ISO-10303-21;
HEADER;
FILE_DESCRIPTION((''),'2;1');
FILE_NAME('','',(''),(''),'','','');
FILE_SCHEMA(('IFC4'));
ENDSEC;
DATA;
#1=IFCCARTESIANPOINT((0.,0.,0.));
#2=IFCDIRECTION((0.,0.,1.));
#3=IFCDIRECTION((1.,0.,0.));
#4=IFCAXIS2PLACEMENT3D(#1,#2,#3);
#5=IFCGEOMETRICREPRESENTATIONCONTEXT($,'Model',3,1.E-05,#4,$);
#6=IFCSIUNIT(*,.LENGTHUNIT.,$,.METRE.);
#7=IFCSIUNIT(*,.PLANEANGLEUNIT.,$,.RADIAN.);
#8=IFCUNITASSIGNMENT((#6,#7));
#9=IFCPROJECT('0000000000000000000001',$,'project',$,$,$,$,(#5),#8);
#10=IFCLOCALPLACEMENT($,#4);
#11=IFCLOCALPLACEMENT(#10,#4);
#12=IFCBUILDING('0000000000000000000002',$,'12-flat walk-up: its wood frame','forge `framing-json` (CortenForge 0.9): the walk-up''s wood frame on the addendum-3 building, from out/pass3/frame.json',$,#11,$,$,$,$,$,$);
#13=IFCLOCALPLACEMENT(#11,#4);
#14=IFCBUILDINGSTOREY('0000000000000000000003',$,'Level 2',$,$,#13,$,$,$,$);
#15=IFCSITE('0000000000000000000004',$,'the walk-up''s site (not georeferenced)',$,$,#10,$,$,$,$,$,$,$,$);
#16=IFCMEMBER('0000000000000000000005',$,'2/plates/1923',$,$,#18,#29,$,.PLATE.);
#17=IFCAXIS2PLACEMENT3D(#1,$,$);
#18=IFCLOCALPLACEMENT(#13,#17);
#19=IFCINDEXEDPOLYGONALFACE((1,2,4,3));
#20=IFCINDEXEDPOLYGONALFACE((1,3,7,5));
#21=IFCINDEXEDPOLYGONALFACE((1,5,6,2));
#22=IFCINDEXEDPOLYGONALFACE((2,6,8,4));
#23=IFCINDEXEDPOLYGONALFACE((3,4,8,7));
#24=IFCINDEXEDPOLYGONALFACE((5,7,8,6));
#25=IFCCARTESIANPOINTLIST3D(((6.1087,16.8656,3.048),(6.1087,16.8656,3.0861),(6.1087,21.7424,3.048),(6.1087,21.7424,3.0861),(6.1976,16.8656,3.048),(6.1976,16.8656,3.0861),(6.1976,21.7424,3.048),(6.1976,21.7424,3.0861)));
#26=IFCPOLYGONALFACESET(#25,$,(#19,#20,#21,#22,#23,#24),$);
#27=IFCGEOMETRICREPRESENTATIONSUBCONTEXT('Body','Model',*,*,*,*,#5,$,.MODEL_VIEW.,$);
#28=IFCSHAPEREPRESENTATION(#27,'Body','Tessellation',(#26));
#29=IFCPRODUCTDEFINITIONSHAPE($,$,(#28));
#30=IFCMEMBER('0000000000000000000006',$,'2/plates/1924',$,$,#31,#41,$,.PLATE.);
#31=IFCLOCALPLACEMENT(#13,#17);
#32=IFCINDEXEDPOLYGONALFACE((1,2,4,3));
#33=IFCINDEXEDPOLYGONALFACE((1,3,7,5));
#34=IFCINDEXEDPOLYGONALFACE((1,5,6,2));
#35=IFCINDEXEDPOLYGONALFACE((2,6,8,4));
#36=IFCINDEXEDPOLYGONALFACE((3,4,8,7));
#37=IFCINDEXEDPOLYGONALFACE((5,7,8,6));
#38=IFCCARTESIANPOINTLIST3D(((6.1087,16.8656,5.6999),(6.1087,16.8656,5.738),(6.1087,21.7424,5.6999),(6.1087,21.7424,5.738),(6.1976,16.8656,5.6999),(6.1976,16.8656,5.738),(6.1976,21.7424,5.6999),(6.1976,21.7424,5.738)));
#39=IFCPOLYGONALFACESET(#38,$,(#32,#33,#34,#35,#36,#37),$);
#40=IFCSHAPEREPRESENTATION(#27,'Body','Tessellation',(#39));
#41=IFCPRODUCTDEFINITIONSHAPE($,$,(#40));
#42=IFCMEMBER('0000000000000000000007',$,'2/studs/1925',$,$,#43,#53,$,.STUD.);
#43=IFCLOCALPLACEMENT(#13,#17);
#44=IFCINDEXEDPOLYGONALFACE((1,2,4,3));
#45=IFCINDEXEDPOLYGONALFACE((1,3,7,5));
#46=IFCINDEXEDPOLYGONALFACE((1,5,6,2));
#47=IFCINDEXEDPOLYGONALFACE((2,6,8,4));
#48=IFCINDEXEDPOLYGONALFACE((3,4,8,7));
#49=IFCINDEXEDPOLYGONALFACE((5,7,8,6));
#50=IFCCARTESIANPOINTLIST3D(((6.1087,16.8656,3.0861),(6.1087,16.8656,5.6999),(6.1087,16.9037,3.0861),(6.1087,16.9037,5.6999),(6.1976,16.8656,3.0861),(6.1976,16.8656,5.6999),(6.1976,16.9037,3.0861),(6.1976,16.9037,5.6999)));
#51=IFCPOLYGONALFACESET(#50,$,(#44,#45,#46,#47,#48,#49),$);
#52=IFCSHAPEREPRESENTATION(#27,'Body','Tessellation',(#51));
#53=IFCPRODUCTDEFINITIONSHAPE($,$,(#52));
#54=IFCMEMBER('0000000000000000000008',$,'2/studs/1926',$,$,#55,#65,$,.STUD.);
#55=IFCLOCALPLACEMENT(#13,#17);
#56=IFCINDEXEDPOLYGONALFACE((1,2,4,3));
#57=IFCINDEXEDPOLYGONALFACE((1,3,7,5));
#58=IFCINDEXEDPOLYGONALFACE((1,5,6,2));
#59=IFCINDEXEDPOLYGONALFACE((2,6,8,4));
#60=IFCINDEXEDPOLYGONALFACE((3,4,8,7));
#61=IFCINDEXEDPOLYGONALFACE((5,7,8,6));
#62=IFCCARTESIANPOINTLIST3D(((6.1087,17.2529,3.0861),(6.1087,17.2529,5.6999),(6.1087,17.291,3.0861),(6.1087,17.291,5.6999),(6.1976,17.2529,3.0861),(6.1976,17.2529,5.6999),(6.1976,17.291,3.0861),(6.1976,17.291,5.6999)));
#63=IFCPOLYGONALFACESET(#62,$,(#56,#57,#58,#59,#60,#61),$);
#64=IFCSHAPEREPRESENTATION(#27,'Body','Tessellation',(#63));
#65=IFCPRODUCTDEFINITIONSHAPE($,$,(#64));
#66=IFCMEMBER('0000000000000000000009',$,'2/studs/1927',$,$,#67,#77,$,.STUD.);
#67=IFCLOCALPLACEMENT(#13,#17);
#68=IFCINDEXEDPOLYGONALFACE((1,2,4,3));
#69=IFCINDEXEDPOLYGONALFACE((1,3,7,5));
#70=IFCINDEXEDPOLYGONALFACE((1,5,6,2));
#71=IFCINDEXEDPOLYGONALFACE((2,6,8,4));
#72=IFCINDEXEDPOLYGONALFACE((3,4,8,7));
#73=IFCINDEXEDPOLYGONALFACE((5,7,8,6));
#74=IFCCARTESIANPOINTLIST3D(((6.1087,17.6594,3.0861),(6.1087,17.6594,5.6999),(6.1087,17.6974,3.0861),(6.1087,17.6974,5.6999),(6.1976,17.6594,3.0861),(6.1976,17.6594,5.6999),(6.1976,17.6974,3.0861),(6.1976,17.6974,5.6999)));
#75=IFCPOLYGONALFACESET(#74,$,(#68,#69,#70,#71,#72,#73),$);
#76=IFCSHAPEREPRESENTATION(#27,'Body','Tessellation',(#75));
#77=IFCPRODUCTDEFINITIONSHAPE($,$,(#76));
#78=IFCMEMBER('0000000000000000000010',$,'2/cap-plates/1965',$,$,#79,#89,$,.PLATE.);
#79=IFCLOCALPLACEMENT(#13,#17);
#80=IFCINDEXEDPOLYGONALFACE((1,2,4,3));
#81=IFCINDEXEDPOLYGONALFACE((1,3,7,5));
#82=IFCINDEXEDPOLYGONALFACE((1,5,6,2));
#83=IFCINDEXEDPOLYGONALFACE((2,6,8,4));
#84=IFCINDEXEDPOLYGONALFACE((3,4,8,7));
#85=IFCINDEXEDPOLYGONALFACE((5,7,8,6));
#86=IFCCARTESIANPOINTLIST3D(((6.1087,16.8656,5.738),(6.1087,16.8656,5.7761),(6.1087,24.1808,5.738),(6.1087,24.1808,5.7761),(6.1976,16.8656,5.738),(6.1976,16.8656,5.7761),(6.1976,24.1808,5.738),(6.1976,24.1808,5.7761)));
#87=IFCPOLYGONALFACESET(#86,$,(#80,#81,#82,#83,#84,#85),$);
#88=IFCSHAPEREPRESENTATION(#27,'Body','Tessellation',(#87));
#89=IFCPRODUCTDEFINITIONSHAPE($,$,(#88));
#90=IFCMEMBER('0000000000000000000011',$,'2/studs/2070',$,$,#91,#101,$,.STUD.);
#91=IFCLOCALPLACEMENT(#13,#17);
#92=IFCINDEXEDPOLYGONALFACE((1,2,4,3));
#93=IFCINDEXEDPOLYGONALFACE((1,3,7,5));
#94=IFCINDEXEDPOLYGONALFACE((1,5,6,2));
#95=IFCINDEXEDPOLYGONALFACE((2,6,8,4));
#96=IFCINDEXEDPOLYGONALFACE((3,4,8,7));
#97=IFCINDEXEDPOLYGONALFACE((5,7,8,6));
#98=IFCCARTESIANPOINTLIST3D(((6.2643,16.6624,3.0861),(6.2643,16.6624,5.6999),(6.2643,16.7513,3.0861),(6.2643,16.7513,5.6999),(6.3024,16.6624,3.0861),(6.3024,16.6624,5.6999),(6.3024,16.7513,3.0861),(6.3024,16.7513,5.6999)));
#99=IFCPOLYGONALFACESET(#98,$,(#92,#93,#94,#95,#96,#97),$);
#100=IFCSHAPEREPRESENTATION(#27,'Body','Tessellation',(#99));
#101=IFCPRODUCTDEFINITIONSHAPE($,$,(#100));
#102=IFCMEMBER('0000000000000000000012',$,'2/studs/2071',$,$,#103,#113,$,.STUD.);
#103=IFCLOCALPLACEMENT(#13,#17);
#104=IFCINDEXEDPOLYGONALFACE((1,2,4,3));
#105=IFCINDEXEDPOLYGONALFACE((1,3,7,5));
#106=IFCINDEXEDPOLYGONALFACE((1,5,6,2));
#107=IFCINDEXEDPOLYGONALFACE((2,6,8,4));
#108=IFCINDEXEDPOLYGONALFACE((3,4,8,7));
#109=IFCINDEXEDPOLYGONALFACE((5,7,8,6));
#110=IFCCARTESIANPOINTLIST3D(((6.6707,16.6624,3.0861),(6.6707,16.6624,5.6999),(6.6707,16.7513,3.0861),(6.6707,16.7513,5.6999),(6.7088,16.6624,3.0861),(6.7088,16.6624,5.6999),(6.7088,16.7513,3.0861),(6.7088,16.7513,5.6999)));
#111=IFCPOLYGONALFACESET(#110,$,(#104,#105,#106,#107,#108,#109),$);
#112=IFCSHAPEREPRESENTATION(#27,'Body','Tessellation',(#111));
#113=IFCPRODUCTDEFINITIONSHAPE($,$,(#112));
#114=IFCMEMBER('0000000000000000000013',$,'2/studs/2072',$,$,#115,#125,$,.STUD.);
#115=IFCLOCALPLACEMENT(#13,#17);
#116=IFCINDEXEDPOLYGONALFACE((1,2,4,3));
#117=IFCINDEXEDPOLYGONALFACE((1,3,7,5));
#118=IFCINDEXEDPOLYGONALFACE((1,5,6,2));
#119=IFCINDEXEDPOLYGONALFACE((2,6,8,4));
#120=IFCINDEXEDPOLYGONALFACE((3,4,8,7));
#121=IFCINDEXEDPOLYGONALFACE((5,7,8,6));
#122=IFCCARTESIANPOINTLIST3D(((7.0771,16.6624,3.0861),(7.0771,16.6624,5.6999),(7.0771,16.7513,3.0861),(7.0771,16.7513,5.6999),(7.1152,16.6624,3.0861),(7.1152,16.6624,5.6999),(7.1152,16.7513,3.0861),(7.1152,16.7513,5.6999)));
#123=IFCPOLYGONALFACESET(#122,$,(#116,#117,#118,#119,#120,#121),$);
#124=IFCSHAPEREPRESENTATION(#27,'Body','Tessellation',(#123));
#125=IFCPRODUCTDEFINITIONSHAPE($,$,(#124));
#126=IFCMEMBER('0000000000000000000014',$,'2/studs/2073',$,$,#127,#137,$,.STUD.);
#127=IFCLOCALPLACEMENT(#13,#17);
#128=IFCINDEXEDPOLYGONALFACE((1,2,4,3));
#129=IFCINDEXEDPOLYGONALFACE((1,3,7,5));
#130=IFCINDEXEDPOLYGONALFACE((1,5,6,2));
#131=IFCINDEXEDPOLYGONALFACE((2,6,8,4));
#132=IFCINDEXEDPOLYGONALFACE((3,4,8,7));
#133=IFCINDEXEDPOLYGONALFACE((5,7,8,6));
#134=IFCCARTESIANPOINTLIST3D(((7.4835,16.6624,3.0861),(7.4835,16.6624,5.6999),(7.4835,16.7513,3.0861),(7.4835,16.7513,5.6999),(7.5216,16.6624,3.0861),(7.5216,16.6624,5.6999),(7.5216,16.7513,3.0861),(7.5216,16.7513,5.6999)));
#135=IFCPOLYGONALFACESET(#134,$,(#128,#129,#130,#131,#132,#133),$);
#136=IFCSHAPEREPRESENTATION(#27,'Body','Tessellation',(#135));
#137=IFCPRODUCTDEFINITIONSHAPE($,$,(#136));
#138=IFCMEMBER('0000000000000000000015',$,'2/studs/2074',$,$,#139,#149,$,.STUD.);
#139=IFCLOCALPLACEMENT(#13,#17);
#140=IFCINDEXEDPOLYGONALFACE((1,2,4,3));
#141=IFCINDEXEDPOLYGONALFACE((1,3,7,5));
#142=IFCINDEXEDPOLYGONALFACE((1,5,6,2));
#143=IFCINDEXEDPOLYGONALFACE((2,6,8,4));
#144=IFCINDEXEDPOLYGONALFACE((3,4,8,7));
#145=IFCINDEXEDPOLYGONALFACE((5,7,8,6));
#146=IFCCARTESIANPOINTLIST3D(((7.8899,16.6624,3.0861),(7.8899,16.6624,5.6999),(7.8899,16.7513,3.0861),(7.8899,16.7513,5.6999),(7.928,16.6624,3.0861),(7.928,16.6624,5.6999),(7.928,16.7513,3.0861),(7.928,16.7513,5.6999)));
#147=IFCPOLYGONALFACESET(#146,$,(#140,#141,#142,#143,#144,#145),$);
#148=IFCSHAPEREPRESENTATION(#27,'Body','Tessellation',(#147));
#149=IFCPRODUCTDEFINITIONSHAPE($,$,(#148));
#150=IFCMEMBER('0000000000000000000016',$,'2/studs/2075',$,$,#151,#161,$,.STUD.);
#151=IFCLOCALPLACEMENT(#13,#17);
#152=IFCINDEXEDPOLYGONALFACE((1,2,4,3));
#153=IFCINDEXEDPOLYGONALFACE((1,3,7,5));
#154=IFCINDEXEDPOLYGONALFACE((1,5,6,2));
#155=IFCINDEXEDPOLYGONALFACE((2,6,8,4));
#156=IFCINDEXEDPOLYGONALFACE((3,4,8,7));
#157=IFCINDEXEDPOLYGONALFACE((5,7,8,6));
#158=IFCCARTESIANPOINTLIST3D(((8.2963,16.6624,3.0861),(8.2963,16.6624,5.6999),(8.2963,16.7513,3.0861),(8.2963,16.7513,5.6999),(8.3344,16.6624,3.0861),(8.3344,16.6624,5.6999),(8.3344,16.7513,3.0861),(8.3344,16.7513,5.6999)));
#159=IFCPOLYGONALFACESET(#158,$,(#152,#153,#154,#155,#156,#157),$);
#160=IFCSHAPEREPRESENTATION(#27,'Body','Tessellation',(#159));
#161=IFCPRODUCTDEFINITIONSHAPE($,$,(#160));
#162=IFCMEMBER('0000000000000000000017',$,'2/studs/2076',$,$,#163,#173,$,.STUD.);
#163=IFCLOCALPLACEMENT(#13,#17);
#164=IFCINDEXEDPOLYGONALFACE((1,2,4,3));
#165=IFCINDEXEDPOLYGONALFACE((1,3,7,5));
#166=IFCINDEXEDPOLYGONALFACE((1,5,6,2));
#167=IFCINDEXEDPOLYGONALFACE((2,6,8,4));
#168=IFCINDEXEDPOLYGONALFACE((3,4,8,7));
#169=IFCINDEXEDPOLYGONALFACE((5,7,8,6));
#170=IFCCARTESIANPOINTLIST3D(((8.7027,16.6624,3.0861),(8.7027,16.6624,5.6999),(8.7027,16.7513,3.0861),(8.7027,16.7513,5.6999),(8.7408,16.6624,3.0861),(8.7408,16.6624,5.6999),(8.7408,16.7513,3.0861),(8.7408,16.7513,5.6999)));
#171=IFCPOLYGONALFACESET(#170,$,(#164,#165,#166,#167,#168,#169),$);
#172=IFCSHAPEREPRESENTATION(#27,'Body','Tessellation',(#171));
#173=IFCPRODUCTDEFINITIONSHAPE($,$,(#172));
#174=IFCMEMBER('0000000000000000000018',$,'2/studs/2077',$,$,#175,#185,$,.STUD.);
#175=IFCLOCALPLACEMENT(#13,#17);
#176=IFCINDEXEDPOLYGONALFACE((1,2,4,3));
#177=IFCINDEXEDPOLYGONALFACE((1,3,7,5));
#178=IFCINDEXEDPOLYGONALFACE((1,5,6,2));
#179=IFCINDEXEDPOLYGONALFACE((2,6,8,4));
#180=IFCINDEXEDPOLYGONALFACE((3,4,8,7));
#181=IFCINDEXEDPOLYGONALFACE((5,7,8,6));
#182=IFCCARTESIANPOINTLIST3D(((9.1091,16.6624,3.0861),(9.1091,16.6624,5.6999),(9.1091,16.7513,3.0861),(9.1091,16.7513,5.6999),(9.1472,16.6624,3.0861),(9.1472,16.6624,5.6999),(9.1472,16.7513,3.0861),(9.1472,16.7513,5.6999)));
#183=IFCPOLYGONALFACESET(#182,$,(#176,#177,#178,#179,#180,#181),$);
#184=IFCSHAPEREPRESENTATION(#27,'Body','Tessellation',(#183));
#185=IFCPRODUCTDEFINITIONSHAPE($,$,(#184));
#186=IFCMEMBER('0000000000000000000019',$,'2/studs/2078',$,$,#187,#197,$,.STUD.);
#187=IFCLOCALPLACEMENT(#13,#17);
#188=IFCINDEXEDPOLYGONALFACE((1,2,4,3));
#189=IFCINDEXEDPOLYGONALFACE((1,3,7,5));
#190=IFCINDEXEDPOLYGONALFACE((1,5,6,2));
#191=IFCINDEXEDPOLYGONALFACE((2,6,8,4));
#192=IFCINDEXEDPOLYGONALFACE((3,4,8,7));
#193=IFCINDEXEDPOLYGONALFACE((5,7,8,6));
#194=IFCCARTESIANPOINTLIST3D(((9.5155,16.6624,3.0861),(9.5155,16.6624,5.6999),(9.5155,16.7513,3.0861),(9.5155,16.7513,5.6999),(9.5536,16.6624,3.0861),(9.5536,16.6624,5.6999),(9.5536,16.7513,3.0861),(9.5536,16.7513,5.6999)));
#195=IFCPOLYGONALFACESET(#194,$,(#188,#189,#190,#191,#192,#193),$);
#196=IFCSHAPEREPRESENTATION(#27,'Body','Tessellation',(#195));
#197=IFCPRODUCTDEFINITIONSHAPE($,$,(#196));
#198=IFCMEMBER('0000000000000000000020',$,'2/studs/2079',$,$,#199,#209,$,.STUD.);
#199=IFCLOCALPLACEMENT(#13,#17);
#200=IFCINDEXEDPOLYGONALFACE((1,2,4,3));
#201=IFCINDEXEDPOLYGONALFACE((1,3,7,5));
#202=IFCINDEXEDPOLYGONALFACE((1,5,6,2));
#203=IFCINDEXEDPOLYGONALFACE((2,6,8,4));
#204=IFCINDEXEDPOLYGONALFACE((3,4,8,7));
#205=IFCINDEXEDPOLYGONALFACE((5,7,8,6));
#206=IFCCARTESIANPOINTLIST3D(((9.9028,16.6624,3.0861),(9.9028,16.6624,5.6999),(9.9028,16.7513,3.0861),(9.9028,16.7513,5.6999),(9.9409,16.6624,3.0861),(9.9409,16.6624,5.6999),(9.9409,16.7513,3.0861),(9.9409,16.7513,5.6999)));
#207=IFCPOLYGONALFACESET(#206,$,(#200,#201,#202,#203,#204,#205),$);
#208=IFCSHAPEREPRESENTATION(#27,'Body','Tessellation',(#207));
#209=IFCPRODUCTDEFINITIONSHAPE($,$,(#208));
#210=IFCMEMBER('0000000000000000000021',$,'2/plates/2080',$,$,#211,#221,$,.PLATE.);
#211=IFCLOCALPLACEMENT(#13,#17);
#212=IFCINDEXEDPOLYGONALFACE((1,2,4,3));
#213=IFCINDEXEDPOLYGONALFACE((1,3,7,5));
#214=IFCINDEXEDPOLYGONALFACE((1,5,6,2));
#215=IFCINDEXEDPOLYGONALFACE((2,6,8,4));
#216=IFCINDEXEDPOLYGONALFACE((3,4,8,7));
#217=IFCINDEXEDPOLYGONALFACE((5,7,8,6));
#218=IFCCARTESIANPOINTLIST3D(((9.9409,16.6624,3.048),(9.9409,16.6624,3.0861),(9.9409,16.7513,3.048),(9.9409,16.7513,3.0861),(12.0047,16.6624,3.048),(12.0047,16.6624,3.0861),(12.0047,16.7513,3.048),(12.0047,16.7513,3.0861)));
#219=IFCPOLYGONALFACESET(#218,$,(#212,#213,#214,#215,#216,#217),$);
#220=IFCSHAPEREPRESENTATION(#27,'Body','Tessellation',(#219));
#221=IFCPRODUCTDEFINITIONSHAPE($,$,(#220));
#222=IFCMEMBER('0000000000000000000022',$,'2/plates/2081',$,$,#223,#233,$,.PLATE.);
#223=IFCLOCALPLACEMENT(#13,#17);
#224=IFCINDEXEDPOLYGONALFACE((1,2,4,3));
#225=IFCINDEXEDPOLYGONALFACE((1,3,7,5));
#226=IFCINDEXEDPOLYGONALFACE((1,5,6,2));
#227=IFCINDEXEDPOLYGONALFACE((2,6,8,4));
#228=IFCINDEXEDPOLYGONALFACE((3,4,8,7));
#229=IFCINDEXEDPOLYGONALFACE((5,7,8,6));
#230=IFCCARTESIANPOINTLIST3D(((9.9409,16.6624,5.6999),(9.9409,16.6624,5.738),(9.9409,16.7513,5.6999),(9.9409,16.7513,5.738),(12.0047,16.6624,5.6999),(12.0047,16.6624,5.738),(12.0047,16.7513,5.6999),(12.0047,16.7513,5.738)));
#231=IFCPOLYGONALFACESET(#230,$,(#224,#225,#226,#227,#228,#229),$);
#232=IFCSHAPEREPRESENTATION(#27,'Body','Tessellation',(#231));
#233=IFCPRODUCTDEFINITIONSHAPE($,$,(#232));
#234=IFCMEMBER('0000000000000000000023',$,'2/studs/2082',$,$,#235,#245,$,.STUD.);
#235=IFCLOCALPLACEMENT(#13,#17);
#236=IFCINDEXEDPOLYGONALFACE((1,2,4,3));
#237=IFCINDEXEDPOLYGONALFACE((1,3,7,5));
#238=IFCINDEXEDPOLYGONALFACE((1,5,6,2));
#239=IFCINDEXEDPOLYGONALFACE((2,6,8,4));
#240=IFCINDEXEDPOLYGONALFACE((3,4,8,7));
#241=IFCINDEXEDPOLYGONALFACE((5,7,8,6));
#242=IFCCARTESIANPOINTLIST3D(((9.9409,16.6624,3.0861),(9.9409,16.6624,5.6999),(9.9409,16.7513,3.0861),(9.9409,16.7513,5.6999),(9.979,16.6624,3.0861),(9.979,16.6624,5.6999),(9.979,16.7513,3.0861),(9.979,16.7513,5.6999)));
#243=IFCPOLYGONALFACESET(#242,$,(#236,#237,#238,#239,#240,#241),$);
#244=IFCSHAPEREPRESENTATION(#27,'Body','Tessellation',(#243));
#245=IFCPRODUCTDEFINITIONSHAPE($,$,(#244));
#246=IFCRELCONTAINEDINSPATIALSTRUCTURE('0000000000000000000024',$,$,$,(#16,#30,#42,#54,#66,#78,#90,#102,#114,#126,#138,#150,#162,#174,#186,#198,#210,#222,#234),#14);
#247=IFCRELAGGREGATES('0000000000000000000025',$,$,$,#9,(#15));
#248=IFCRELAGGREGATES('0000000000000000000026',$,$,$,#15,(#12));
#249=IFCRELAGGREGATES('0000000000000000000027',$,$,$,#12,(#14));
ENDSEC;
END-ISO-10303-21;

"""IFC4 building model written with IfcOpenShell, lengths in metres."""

from ifc_helpers import new_model, si_unit, frame, frame_2d, origin, origin_with_axes, place, context, subcontext, project, spatial, rectangle, extrude, element, save


model = new_model("IFC4")

# Units and contexts
model_context = context("Model", 3, precision=1e-05, world=origin_with_axes())
body_context = subcontext(model_context, "Body", "Model", "MODEL_VIEW")
ifc_project = project(units=[si_unit("LENGTHUNIT", "METRE"), si_unit("PLANEANGLEUNIT", "RADIAN")], contexts=[model_context])

# Site, building, storey
site_placement = place(None, origin_with_axes())
site = spatial("IfcSite", under=ifc_project, at=site_placement, Name="the walk-up's site (not georeferenced)")
building_placement = place(site_placement, origin_with_axes())
building = spatial("IfcBuilding", under=site, at=building_placement, Name="12-flat walk-up: its wood frame", Description="forge `framing-json` (CortenForge 0.9): the walk-up's wood frame on the addendum-3 building, from out/pass3/frame.json")
storey_placement = place(building_placement, origin_with_axes())
storey = spatial("IfcBuildingStorey", under=building, at=storey_placement, Name="Level 2")

# Members
for number, where, z_axis, x_axis, name in (
    (1, (6.1087, 16.8656, 3.048), (0.0, 0.0, 1.0), (1.0, 0.0, 0.0), "2/plates/1923"),
    (2, (6.1087, 16.8656, 5.6999), (0.0, 0.0, 1.0), (1.0, 0.0, 0.0), "2/plates/1924"),
):
    element("IfcMember", number, at=place(storey_placement, frame(where, z_axis=z_axis, x_axis=x_axis)), inside=storey, Name=name, PredefinedType="PLATE", context=body_context, shape_type="SweptSolid", body=[
        extrude(rectangle(XDim=0.0889, YDim=4.8768, at=frame_2d((0.0445, 2.4384))), origin(), (0.0, 0.0, 1.0), 0.0381),
    ])
for number, where, z_axis, x_axis, name in (
    (3, (6.1087, 16.8656, 3.0861), (0.0, 0.0, 1.0), (1.0, 0.0, 0.0), "2/studs/1925"),
    (4, (6.1087, 17.2529, 3.0861), (0.0, 0.0, 1.0), (1.0, 0.0, 0.0), "2/studs/1926"),
    (5, (6.1087, 17.6593, 3.0861), (0.0, 0.0, 1.0), (1.0, 0.0, 0.0), "2/studs/1927"),
):
    element("IfcMember", number, at=place(storey_placement, frame(where, z_axis=z_axis, x_axis=x_axis)), inside=storey, Name=name, PredefinedType="STUD", context=body_context, shape_type="SweptSolid", body=[
        extrude(rectangle(XDim=0.0889, YDim=0.0381, at=frame_2d((0.0445, 0.0191))), origin(), (0.0, 0.0, 1.0), 2.6138),
    ])
member_1_placement = place(storey_placement, frame((6.1087, 16.8656, 5.738), z_axis=(0.0, 0.0, 1.0), x_axis=(1.0, 0.0, 0.0)))
element("IfcMember", 6, at=member_1_placement, inside=storey, Name="2/cap-plates/1965", PredefinedType="PLATE", context=body_context, shape_type="SweptSolid", body=[
    extrude(rectangle(XDim=0.0889, YDim=7.3152, at=frame_2d((0.0445, 3.6576))), origin(), (0.0, 0.0, 1.0), 0.0381),
])
for number, where, z_axis, x_axis, name in (
    (7, (6.2643, 16.6624, 3.0861), (0.0, 0.0, 1.0), (1.0, 0.0, 0.0), "2/studs/2070"),
    (8, (6.6707, 16.6624, 3.0861), (0.0, 0.0, 1.0), (1.0, 0.0, 0.0), "2/studs/2071"),
    (9, (7.0771, 16.6624, 3.0861), (0.0, 0.0, 1.0), (1.0, 0.0, 0.0), "2/studs/2072"),
    (10, (7.4835, 16.6624, 3.0861), (0.0, 0.0, 1.0), (1.0, 0.0, 0.0), "2/studs/2073"),
    (11, (7.8899, 16.6624, 3.0861), (0.0, 0.0, 1.0), (1.0, 0.0, 0.0), "2/studs/2074"),
    (12, (8.2963, 16.6624, 3.0861), (0.0, 0.0, 1.0), (1.0, 0.0, 0.0), "2/studs/2075"),
    (13, (8.7027, 16.6624, 3.0861), (0.0, 0.0, 1.0), (1.0, 0.0, 0.0), "2/studs/2076"),
    (14, (9.1091, 16.6624, 3.0861), (0.0, 0.0, 1.0), (1.0, 0.0, 0.0), "2/studs/2077"),
    (15, (9.5155, 16.6624, 3.0861), (0.0, 0.0, 1.0), (1.0, 0.0, 0.0), "2/studs/2078"),
    (16, (9.9028, 16.6624, 3.0861), (0.0, 0.0, 1.0), (1.0, 0.0, 0.0), "2/studs/2079"),
):
    element("IfcMember", number, at=place(storey_placement, frame(where, z_axis=z_axis, x_axis=x_axis)), inside=storey, Name=name, PredefinedType="STUD", context=body_context, shape_type="SweptSolid", body=[
        extrude(rectangle(XDim=0.0381, YDim=0.0889, at=frame_2d((0.0191, 0.0444))), origin(), (0.0, 0.0, 1.0), 2.6138),
    ])
for number, where, z_axis, x_axis, name in (
    (17, (9.9409, 16.6624, 3.048), (0.0, 0.0, 1.0), (1.0, 0.0, 0.0), "2/plates/2080"),
    (18, (9.9409, 16.6624, 5.6999), (0.0, 0.0, 1.0), (1.0, 0.0, 0.0), "2/plates/2081"),
):
    element("IfcMember", number, at=place(storey_placement, frame(where, z_axis=z_axis, x_axis=x_axis)), inside=storey, Name=name, PredefinedType="PLATE", context=body_context, shape_type="SweptSolid", body=[
        extrude(rectangle(XDim=2.0638, YDim=0.0889, at=frame_2d((1.0319, 0.0444))), origin(), (0.0, 0.0, 1.0), 0.0381),
    ])
member_2_placement = place(storey_placement, frame((9.9409, 16.6624, 3.0861), z_axis=(0.0, 0.0, 1.0), x_axis=(1.0, 0.0, 0.0)))
element("IfcMember", 19, at=member_2_placement, inside=storey, Name="2/studs/2082", PredefinedType="STUD", context=body_context, shape_type="SweptSolid", body=[
    extrude(rectangle(XDim=0.0381, YDim=0.0889, at=frame_2d((0.0191, 0.0444))), origin(), (0.0, 0.0, 1.0), 2.6138),
])

save(model, "model.ifc")
